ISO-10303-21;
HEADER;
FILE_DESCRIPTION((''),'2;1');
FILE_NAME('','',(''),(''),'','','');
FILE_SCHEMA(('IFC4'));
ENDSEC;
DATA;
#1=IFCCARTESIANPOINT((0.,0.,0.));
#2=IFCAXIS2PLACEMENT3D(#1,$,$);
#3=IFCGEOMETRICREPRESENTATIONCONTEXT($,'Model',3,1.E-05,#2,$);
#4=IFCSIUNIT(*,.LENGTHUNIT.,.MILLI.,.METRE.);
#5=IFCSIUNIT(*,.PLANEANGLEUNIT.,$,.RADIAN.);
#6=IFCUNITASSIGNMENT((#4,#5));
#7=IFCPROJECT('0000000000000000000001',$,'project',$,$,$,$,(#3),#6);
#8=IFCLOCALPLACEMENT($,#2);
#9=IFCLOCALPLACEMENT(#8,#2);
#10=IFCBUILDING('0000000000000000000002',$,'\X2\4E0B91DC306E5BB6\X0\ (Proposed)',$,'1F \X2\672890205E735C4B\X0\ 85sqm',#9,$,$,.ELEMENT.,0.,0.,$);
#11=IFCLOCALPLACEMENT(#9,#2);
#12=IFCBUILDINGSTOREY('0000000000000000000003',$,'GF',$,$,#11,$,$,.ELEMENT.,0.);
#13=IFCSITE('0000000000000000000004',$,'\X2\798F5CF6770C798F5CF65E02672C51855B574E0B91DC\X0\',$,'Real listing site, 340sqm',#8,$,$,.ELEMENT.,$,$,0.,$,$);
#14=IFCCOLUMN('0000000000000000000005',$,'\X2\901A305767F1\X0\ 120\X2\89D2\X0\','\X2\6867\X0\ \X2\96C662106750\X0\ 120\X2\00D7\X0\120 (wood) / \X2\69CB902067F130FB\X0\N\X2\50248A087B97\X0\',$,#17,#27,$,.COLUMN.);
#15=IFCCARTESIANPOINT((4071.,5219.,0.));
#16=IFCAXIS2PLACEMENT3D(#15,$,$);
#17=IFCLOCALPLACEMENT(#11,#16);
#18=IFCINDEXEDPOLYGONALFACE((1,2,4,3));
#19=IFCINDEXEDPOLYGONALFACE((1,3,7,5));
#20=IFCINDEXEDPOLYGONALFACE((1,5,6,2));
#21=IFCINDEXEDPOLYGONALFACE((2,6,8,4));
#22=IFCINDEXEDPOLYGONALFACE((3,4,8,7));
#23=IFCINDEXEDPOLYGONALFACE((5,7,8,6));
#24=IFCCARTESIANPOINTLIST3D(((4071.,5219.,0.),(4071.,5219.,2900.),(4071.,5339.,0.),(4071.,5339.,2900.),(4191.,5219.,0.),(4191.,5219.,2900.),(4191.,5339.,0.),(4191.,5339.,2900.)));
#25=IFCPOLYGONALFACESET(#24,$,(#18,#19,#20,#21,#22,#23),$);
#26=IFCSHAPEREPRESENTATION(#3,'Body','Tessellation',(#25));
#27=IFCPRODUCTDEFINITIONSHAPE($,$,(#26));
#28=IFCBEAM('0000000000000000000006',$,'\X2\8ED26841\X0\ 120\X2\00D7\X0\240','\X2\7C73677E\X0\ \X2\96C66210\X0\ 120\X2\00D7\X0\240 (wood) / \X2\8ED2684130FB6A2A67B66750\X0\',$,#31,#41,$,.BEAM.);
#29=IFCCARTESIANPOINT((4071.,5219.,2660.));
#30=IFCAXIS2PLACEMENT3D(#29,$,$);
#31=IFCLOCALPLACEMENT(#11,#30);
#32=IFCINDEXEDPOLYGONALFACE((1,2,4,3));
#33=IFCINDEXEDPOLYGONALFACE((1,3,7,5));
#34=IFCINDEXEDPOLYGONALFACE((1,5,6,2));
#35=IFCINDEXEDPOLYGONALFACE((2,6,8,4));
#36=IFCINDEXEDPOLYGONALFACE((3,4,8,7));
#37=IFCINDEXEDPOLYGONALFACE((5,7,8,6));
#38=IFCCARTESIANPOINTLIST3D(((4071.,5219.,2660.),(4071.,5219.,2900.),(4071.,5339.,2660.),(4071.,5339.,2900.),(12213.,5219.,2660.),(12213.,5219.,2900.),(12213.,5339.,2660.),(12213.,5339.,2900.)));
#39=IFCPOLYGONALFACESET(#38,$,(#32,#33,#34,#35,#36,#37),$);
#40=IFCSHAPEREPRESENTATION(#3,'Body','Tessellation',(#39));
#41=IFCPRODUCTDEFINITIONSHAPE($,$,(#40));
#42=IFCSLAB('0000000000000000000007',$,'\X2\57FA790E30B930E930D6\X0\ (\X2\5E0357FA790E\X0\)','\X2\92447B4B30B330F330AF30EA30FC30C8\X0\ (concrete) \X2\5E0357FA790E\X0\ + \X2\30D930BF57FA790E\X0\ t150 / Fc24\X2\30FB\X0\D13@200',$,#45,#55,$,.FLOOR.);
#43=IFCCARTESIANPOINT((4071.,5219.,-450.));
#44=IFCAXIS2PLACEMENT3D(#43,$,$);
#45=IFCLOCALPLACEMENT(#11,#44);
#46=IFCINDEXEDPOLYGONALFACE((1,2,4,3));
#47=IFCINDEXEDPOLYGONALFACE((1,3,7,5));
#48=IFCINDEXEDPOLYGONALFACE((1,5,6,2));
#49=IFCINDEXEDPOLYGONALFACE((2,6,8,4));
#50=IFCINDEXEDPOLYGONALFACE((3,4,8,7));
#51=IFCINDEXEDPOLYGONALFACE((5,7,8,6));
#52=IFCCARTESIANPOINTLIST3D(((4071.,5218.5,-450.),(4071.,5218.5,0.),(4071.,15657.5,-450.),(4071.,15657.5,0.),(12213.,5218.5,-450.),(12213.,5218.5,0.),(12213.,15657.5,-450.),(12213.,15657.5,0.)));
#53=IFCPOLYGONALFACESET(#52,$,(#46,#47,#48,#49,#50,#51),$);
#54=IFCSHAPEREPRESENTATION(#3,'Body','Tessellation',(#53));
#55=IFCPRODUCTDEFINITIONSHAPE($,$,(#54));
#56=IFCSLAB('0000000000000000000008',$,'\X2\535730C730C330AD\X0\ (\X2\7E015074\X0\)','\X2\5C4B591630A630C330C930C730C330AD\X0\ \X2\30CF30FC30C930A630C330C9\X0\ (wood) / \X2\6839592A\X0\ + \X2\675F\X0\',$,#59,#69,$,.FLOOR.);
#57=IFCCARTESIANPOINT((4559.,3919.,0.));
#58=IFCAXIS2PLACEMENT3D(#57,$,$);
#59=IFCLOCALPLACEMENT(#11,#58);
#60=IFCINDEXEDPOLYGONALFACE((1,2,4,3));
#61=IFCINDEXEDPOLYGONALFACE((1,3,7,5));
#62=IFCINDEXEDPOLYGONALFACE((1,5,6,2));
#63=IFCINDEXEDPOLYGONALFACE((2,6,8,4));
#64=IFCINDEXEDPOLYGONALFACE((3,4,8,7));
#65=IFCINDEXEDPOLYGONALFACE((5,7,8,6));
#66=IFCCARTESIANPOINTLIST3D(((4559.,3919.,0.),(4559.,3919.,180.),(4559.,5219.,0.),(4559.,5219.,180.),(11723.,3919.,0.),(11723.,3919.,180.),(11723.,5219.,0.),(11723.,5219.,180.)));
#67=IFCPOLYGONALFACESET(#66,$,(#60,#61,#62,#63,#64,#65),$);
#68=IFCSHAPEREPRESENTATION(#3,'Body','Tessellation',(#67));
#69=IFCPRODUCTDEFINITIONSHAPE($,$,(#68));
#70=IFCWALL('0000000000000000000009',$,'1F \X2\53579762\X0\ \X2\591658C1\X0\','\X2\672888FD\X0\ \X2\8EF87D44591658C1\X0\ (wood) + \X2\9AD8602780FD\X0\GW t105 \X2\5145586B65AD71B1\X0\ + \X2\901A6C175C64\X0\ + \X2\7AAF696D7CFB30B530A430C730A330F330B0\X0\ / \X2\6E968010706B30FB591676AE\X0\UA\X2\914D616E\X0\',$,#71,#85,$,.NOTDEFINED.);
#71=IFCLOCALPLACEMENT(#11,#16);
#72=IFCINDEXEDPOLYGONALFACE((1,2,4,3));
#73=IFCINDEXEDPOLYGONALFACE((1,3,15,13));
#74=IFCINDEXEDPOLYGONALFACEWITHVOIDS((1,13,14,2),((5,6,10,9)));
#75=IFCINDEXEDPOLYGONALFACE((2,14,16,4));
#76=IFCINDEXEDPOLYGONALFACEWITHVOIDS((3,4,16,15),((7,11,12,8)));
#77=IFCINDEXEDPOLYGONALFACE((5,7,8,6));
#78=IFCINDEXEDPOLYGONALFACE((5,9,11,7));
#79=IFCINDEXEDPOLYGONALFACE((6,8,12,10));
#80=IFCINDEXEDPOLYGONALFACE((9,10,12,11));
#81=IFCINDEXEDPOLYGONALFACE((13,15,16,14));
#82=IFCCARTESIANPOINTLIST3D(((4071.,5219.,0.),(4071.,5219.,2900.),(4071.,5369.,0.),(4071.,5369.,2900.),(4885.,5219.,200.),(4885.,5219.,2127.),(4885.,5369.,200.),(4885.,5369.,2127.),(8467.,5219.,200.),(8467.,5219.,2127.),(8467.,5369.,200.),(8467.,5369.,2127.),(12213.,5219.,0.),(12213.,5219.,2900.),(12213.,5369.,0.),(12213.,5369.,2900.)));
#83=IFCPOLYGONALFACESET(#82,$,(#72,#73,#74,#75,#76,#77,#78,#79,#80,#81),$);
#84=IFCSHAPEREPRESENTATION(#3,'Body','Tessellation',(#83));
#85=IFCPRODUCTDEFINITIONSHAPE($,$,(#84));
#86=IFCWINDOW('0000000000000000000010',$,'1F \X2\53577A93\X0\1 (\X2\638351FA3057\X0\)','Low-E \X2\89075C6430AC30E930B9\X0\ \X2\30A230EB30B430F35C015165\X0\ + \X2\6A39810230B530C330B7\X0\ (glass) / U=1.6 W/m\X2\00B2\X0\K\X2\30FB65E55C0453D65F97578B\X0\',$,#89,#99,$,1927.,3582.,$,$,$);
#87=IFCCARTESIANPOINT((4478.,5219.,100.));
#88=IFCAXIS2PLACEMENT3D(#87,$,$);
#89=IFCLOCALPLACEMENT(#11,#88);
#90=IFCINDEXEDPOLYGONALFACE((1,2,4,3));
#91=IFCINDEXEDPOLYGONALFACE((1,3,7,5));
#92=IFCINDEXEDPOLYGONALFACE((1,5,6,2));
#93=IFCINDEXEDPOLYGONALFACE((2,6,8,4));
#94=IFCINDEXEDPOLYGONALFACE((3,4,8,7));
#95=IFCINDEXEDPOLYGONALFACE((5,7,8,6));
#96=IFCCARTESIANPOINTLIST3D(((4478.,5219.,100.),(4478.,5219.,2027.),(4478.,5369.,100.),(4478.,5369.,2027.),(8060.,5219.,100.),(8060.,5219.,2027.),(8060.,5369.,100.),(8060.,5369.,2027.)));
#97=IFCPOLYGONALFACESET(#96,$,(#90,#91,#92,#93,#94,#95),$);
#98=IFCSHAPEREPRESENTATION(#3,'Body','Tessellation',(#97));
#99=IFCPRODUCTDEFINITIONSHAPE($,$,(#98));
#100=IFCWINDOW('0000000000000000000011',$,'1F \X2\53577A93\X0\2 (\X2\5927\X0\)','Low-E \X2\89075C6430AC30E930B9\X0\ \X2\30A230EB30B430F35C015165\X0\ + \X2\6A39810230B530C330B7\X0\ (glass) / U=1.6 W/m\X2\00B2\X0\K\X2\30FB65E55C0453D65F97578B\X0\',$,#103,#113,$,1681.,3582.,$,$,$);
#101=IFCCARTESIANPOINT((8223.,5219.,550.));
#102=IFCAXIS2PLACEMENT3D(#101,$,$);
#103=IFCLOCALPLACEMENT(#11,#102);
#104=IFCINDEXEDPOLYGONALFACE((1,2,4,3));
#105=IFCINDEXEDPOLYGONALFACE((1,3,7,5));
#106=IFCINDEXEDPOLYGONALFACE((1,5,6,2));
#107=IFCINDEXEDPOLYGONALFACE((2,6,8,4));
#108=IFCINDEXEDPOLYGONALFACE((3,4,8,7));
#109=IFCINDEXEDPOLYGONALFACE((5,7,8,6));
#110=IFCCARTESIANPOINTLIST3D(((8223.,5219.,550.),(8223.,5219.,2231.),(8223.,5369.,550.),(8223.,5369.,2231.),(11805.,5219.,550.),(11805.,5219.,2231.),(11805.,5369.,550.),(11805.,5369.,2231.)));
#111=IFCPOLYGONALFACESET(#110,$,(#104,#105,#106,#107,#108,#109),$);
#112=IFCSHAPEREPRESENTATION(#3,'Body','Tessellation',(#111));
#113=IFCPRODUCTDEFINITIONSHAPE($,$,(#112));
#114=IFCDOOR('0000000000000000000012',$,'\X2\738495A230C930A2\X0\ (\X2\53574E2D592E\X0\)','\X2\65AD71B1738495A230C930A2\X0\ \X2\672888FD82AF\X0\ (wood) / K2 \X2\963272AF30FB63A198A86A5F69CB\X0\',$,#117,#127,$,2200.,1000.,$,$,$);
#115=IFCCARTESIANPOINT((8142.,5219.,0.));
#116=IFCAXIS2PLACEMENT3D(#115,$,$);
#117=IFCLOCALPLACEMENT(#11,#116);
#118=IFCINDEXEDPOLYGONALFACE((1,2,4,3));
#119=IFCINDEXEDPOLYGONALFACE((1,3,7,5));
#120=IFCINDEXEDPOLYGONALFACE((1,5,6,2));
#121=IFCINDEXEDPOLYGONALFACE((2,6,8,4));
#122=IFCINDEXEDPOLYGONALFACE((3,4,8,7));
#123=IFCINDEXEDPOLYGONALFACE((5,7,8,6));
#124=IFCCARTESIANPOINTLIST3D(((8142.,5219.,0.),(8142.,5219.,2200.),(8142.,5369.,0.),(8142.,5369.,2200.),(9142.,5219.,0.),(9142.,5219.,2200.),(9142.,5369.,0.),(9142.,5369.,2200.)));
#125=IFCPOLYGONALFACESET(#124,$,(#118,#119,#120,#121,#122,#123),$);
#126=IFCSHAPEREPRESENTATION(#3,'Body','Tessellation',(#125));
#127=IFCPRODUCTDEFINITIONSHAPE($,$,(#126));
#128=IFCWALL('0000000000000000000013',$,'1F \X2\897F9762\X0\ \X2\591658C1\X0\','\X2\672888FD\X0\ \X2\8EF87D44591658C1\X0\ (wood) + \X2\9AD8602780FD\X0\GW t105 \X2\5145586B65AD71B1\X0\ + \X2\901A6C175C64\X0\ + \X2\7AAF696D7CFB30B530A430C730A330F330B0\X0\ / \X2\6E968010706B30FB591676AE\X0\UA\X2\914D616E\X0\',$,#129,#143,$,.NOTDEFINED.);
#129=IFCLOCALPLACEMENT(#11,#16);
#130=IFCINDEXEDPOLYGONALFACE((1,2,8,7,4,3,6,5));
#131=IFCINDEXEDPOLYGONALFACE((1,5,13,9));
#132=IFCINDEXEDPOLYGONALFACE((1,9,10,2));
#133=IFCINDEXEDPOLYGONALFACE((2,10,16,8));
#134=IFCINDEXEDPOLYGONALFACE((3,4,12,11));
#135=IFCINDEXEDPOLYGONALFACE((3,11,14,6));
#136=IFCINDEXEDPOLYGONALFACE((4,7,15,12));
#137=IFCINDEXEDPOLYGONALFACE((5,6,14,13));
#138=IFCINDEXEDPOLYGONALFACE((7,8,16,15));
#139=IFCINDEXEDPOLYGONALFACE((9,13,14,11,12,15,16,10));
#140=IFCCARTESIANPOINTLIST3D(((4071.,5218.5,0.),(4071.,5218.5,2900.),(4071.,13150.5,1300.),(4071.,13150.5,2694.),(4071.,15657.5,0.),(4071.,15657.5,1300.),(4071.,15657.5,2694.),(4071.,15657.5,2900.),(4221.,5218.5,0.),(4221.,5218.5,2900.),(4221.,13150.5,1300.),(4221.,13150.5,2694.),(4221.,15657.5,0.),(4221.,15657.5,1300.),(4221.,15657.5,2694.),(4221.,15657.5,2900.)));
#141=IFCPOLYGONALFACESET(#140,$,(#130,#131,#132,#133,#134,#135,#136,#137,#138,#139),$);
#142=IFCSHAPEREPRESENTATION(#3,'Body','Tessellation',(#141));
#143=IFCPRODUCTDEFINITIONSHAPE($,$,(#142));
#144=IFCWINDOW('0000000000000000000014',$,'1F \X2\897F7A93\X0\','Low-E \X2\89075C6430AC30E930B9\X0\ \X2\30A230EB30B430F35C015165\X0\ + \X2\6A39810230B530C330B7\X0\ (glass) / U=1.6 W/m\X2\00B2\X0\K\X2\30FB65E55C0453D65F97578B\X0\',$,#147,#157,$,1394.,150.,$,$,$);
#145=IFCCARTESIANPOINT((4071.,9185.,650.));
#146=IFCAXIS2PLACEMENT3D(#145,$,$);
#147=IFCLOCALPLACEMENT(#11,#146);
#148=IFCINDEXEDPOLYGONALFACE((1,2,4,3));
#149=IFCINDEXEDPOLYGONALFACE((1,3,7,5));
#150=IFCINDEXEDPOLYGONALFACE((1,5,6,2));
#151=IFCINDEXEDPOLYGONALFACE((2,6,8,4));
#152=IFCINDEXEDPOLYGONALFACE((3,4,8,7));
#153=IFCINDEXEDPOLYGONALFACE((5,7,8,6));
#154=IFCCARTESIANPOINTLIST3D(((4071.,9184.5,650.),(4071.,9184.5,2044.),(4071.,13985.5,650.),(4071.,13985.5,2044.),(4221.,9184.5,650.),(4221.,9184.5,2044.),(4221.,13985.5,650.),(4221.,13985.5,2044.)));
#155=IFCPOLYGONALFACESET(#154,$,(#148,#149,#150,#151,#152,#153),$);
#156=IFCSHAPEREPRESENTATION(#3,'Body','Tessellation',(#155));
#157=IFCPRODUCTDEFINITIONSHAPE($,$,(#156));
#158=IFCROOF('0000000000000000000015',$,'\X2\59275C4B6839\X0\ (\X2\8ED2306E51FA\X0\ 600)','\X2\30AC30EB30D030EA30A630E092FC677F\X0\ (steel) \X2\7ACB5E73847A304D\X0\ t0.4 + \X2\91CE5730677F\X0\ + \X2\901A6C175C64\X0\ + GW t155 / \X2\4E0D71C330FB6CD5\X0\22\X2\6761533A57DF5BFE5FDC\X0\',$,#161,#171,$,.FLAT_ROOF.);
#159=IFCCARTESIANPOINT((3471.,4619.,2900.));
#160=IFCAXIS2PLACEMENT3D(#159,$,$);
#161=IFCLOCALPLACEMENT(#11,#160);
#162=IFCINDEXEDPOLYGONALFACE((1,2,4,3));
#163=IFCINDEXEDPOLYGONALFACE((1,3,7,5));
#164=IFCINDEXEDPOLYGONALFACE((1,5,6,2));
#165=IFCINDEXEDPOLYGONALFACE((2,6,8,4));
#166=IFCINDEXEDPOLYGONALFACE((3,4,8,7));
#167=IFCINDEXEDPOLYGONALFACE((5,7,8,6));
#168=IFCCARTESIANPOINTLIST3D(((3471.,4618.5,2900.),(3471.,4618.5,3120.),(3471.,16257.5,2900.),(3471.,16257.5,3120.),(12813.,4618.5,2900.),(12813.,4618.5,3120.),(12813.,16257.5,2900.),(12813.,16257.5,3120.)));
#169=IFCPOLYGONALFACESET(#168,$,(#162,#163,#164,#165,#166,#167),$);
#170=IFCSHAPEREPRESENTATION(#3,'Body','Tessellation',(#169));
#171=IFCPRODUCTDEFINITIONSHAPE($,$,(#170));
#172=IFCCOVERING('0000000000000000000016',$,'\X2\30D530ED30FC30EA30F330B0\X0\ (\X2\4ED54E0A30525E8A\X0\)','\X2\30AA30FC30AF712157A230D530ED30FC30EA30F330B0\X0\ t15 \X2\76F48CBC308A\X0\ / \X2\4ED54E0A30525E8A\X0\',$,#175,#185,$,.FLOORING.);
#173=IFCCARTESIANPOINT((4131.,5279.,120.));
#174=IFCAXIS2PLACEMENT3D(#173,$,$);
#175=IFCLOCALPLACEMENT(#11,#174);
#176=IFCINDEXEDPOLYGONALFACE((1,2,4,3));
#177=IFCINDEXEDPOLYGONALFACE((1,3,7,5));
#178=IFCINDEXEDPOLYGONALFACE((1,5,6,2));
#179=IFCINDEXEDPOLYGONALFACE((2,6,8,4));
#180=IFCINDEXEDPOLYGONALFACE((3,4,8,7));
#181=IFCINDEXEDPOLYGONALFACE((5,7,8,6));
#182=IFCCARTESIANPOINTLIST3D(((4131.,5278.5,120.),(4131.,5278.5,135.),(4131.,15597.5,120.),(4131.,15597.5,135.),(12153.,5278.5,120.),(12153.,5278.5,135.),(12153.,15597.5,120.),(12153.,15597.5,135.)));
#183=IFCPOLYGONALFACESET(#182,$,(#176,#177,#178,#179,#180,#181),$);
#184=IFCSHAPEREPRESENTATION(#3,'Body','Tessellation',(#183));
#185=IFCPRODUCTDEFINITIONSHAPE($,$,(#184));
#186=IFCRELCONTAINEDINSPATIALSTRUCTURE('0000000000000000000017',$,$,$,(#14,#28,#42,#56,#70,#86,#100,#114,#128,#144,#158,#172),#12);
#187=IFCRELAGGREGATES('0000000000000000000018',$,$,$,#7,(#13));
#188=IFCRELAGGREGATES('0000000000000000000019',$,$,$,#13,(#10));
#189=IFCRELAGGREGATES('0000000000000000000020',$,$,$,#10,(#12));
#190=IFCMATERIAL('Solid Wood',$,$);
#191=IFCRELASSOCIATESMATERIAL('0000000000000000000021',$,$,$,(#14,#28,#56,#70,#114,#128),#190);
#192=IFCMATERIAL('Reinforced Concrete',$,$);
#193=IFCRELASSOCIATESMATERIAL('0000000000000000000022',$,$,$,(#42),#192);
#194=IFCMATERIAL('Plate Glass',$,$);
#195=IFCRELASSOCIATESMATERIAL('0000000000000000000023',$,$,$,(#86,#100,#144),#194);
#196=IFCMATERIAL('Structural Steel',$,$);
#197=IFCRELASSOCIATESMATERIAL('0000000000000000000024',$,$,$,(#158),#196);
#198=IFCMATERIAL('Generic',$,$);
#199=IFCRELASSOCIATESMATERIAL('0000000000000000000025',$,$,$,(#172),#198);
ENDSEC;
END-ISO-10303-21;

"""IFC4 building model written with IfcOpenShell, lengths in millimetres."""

from ifc_helpers import new_model, si_unit, frame, frame_2d, origin, place, context, project, spatial, rectangle, extrude, material, element, fill, save


model = new_model("IFC4")

# Units and contexts
model_context = context("Model", 3, precision=1e-05, world=origin())
ifc_project = project(units=[si_unit("LENGTHUNIT", "METRE", prefix="MILLI"), si_unit("PLANEANGLEUNIT", "RADIAN")], contexts=[model_context])

# Site, building, storey
site_placement = place(None, origin())
site = spatial("IfcSite", under=ifc_project, at=site_placement, Name="福島県福島市本内字下釜", ObjectType="Real listing site, 340sqm", CompositionType="ELEMENT", RefElevation=0.0)
building_placement = place(site_placement, origin())
building = spatial("IfcBuilding", under=site, at=building_placement, Name="下釜の家 (Proposed)", ObjectType="1F 木造平屋 85sqm", CompositionType="ELEMENT", ElevationOfRefHeight=0.0, ElevationOfTerrain=0.0)
storey_placement = place(building_placement, origin())
storey = spatial("IfcBuildingStorey", under=building, at=storey_placement, Name="GF", CompositionType="ELEMENT", Elevation=0.0)

# Column
ifc_material_1 = material(Name="Solid Wood")
column_1_placement = place(storey_placement, frame((4071.0, 5219.0, 0.0)))
element("IfcColumn", 1, at=column_1_placement, inside=storey, material=ifc_material_1, Name="通し柱 120角", Description="桧 集成材 120×120 (wood) / 構造柱・N値計算", PredefinedType="COLUMN", context=model_context, shape_type="SweptSolid", body=[
    extrude(rectangle(XDim=120.0, YDim=120.0, at=frame_2d((60.0, 60.0))), frame((4071.0, 5219.0, 0.0)), (0.0, 0.0, 1.0), 2900.0),
])

# Beam
beam_1_placement = place(storey_placement, frame((4071.0, 5219.0, 2660.0)))
element("IfcBeam", 2, at=beam_1_placement, inside=storey, material=ifc_material_1, Name="軒桁 120×240", Description="米松 集成 120×240 (wood) / 軒桁・横架材", PredefinedType="BEAM", context=model_context, shape_type="SweptSolid", body=[
    extrude(rectangle(XDim=8142.0, YDim=120.0, at=frame_2d((4071.0, 60.0))), frame((4071.0, 5219.0, 2660.0)), (0.0, 0.0, 1.0), 240.0),
])

# Slabs
ifc_material_2 = material(Name="Reinforced Concrete")
slab_1_placement = place(storey_placement, frame((4071.0, 5219.0, -450.0)))
element("IfcSlab", 3, at=slab_1_placement, inside=storey, material=ifc_material_2, Name="基礎スラブ (布基礎)", Description="鉄筋コンクリート (concrete) 布基礎 + ベタ基礎 t150 / Fc24・D13@200", PredefinedType="FLOOR", context=model_context, shape_type="SweptSolid", body=[
    extrude(rectangle(XDim=8142.0, YDim=10439.0, at=frame_2d((4071.0, 5219.0))), frame((4071.0, 5219.0, -450.0)), (0.0, 0.0, 1.0), 450.0),
])
slab_2_placement = place(storey_placement, frame((4559.0, 3919.0, 0.0)))
element("IfcSlab", 4, at=slab_2_placement, inside=storey, material=ifc_material_1, Name="南デッキ (縁側)", Description="屋外ウッドデッキ ハードウッド (wood) / 根太 + 束", PredefinedType="FLOOR", context=model_context, shape_type="SweptSolid", body=[
    extrude(rectangle(XDim=7164.0, YDim=1300.0, at=frame_2d((3582.0, 650.0))), frame((4559.0, 3919.0, 0.0)), (0.0, 0.0, 1.0), 180.0),
])

# Wall, openings, windows, door
wall_1_placement = place(storey_placement, frame((4071.0, 5219.0, 0.0)))
wall_1 = element("IfcWall", 5, at=wall_1_placement, inside=storey, material=ifc_material_1, Name="1F 南面 外壁", Description="木製 軸組外壁 (wood) + 高性能GW t105 充填断熱 + 通気層 + 窯業系サイディング / 準耐火・外皮UA配慮", PredefinedType="NOTDEFINED", context=model_context, shape_type="SweptSolid", body=[
    extrude(rectangle(XDim=8142.0, YDim=150.0, at=frame_2d((4071.0, 75.0))), frame((4071.0, 5219.0, 0.0)), (0.0, 0.0, 1.0), 2900.0),
])
opening_1_placement = place(storey_placement, frame((4478.0, 5219.0, 100.0)))
opening_1 = element("IfcOpeningElement", 6, at=opening_1_placement, cuts=wall_1, PredefinedType="NOTDEFINED", context=model_context, shape_type="SweptSolid", body=[
    extrude(rectangle(XDim=3582.0, YDim=150.0, at=frame_2d((1791.0, 75.0))), frame((4478.0, 5219.0, 100.0)), (0.0, 0.0, 1.0), 1927.0),
])
opening_2_placement = place(storey_placement, frame((8223.0, 5219.0, 550.0)))
opening_2 = element("IfcOpeningElement", 7, at=opening_2_placement, cuts=wall_1, PredefinedType="NOTDEFINED", context=model_context, shape_type="SweptSolid", body=[
    extrude(rectangle(XDim=3582.0, YDim=150.0, at=frame_2d((1791.0, 75.0))), frame((8223.0, 5219.0, 550.0)), (0.0, 0.0, 1.0), 1681.0),
])
opening_3_placement = place(storey_placement, frame((8142.0, 5219.0, 0.0)))
opening_3 = element("IfcOpeningElement", 8, at=opening_3_placement, cuts=wall_1, PredefinedType="NOTDEFINED", context=model_context, shape_type="SweptSolid", body=[
    extrude(rectangle(XDim=1000.0, YDim=150.0, at=frame_2d((500.0, 75.0))), frame((8142.0, 5219.0, 0.0)), (0.0, 0.0, 1.0), 2200.0),
])
ifc_material_3 = material(Name="Plate Glass")
window_1_placement = place(storey_placement, frame((4478.0, 5219.0, 100.0)))
window_1 = element("IfcWindow", 9, at=window_1_placement, inside=storey, material=ifc_material_3, Name="1F 南窓1 (掃出し)", Description="Low-E 複層ガラス アルゴン封入 + 樹脂サッシ (glass) / U=1.6 W/m²K・日射取得型", OverallHeight=1927.0, OverallWidth=3582.0, context=model_context, shape_type="SweptSolid", body=[
    extrude(rectangle(XDim=3582.0, YDim=150.0, at=frame_2d((1791.0, 75.0))), frame((4478.0, 5219.0, 100.0)), (0.0, 0.0, 1.0), 1927.0),
])
fill(opening_1, window_1)
window_2_placement = place(storey_placement, frame((8223.0, 5219.0, 550.0)))
window_2 = element("IfcWindow", 10, at=window_2_placement, inside=storey, material=ifc_material_3, Name="1F 南窓2 (大)", Description="Low-E 複層ガラス アルゴン封入 + 樹脂サッシ (glass) / U=1.6 W/m²K・日射取得型", OverallHeight=1681.0, OverallWidth=3582.0, context=model_context, shape_type="SweptSolid", body=[
    extrude(rectangle(XDim=3582.0, YDim=150.0, at=frame_2d((1791.0, 75.0))), frame((8223.0, 5219.0, 550.0)), (0.0, 0.0, 1.0), 1681.0),
])
fill(opening_2, window_2)
door_placement = place(storey_placement, frame((8142.0, 5219.0, 0.0)))
door = element("IfcDoor", 11, at=door_placement, inside=storey, material=ifc_material_1, Name="玄関ドア (南中央)", Description="断熱玄関ドア 木製芯 (wood) / K2 防犯・採風機構", OverallHeight=2200.0, OverallWidth=1000.0, context=model_context, shape_type="SweptSolid", body=[
    extrude(rectangle(XDim=1000.0, YDim=150.0, at=frame_2d((500.0, 75.0))), frame((8142.0, 5219.0, 0.0)), (0.0, 0.0, 1.0), 2200.0),
])
fill(opening_3, door)

# Wall, opening, window
wall_2_placement = place(storey_placement, frame((4071.0, 5219.0, 0.0)))
wall_2 = element("IfcWall", 12, at=wall_2_placement, inside=storey, material=ifc_material_1, Name="1F 西面 外壁", Description="木製 軸組外壁 (wood) + 高性能GW t105 充填断熱 + 通気層 + 窯業系サイディング / 準耐火・外皮UA配慮", PredefinedType="NOTDEFINED", context=model_context, shape_type="SweptSolid", body=[
    extrude(rectangle(XDim=150.0, YDim=10439.0, at=frame_2d((75.0, 5219.0))), frame((4071.0, 5219.0, 0.0)), (0.0, 0.0, 1.0), 2900.0),
])
opening_4_placement = place(storey_placement, frame((4071.0, 9185.0, 650.0)))
opening_4 = element("IfcOpeningElement", 13, at=opening_4_placement, cuts=wall_2, PredefinedType="NOTDEFINED", context=model_context, shape_type="SweptSolid", body=[
    extrude(rectangle(XDim=150.0, YDim=4801.0, at=frame_2d((75.0, 2400.0))), frame((4071.0, 9185.0, 650.0)), (0.0, 0.0, 1.0), 1394.0),
])
window_3_placement = place(storey_placement, frame((4071.0, 9185.0, 650.0)))
window_3 = element("IfcWindow", 14, at=window_3_placement, inside=storey, material=ifc_material_3, Name="1F 西窓", Description="Low-E 複層ガラス アルゴン封入 + 樹脂サッシ (glass) / U=1.6 W/m²K・日射取得型", OverallHeight=1394.0, OverallWidth=150.0, context=model_context, shape_type="SweptSolid", body=[
    extrude(rectangle(XDim=150.0, YDim=4801.0, at=frame_2d((75.0, 2400.0))), frame((4071.0, 9185.0, 650.0)), (0.0, 0.0, 1.0), 1394.0),
])
fill(opening_4, window_3)

# Roof
ifc_material_4 = material(Name="Structural Steel")
roof_placement = place(storey_placement, frame((3471.0, 4619.0, 2900.0)))
element("IfcRoof", 15, at=roof_placement, inside=storey, material=ifc_material_4, Name="大屋根 (軒の出 600)", Description="ガルバリウム鋼板 (steel) 立平葺き t0.4 + 野地板 + 通気層 + GW t155 / 不燃・法22条区域対応", PredefinedType="FLAT_ROOF", context=model_context, shape_type="SweptSolid", body=[
    extrude(rectangle(XDim=9342.0, YDim=11639.0, at=frame_2d((4671.0, 5819.0))), frame((3471.0, 4619.0, 2900.0)), (0.0, 0.0, 1.0), 220.0),
])

# Covering
ifc_material_5 = material(Name="Generic")
covering_1_placement = place(storey_placement, frame((4131.0, 5279.0, 120.0)))
element("IfcCovering", 16, at=covering_1_placement, inside=storey, material=ifc_material_5, Name="フローリング (仕上げ床)", Description="オーク無垢フローリング t15 直貼り / 仕上げ床", PredefinedType="FLOORING", context=model_context, shape_type="SweptSolid", body=[
    extrude(rectangle(XDim=8022.0, YDim=10319.0, at=frame_2d((4011.0, 5159.0))), frame((4131.0, 5279.0, 120.0)), (0.0, 0.0, 1.0), 15.0),
])

save(model, "model.ifc")
